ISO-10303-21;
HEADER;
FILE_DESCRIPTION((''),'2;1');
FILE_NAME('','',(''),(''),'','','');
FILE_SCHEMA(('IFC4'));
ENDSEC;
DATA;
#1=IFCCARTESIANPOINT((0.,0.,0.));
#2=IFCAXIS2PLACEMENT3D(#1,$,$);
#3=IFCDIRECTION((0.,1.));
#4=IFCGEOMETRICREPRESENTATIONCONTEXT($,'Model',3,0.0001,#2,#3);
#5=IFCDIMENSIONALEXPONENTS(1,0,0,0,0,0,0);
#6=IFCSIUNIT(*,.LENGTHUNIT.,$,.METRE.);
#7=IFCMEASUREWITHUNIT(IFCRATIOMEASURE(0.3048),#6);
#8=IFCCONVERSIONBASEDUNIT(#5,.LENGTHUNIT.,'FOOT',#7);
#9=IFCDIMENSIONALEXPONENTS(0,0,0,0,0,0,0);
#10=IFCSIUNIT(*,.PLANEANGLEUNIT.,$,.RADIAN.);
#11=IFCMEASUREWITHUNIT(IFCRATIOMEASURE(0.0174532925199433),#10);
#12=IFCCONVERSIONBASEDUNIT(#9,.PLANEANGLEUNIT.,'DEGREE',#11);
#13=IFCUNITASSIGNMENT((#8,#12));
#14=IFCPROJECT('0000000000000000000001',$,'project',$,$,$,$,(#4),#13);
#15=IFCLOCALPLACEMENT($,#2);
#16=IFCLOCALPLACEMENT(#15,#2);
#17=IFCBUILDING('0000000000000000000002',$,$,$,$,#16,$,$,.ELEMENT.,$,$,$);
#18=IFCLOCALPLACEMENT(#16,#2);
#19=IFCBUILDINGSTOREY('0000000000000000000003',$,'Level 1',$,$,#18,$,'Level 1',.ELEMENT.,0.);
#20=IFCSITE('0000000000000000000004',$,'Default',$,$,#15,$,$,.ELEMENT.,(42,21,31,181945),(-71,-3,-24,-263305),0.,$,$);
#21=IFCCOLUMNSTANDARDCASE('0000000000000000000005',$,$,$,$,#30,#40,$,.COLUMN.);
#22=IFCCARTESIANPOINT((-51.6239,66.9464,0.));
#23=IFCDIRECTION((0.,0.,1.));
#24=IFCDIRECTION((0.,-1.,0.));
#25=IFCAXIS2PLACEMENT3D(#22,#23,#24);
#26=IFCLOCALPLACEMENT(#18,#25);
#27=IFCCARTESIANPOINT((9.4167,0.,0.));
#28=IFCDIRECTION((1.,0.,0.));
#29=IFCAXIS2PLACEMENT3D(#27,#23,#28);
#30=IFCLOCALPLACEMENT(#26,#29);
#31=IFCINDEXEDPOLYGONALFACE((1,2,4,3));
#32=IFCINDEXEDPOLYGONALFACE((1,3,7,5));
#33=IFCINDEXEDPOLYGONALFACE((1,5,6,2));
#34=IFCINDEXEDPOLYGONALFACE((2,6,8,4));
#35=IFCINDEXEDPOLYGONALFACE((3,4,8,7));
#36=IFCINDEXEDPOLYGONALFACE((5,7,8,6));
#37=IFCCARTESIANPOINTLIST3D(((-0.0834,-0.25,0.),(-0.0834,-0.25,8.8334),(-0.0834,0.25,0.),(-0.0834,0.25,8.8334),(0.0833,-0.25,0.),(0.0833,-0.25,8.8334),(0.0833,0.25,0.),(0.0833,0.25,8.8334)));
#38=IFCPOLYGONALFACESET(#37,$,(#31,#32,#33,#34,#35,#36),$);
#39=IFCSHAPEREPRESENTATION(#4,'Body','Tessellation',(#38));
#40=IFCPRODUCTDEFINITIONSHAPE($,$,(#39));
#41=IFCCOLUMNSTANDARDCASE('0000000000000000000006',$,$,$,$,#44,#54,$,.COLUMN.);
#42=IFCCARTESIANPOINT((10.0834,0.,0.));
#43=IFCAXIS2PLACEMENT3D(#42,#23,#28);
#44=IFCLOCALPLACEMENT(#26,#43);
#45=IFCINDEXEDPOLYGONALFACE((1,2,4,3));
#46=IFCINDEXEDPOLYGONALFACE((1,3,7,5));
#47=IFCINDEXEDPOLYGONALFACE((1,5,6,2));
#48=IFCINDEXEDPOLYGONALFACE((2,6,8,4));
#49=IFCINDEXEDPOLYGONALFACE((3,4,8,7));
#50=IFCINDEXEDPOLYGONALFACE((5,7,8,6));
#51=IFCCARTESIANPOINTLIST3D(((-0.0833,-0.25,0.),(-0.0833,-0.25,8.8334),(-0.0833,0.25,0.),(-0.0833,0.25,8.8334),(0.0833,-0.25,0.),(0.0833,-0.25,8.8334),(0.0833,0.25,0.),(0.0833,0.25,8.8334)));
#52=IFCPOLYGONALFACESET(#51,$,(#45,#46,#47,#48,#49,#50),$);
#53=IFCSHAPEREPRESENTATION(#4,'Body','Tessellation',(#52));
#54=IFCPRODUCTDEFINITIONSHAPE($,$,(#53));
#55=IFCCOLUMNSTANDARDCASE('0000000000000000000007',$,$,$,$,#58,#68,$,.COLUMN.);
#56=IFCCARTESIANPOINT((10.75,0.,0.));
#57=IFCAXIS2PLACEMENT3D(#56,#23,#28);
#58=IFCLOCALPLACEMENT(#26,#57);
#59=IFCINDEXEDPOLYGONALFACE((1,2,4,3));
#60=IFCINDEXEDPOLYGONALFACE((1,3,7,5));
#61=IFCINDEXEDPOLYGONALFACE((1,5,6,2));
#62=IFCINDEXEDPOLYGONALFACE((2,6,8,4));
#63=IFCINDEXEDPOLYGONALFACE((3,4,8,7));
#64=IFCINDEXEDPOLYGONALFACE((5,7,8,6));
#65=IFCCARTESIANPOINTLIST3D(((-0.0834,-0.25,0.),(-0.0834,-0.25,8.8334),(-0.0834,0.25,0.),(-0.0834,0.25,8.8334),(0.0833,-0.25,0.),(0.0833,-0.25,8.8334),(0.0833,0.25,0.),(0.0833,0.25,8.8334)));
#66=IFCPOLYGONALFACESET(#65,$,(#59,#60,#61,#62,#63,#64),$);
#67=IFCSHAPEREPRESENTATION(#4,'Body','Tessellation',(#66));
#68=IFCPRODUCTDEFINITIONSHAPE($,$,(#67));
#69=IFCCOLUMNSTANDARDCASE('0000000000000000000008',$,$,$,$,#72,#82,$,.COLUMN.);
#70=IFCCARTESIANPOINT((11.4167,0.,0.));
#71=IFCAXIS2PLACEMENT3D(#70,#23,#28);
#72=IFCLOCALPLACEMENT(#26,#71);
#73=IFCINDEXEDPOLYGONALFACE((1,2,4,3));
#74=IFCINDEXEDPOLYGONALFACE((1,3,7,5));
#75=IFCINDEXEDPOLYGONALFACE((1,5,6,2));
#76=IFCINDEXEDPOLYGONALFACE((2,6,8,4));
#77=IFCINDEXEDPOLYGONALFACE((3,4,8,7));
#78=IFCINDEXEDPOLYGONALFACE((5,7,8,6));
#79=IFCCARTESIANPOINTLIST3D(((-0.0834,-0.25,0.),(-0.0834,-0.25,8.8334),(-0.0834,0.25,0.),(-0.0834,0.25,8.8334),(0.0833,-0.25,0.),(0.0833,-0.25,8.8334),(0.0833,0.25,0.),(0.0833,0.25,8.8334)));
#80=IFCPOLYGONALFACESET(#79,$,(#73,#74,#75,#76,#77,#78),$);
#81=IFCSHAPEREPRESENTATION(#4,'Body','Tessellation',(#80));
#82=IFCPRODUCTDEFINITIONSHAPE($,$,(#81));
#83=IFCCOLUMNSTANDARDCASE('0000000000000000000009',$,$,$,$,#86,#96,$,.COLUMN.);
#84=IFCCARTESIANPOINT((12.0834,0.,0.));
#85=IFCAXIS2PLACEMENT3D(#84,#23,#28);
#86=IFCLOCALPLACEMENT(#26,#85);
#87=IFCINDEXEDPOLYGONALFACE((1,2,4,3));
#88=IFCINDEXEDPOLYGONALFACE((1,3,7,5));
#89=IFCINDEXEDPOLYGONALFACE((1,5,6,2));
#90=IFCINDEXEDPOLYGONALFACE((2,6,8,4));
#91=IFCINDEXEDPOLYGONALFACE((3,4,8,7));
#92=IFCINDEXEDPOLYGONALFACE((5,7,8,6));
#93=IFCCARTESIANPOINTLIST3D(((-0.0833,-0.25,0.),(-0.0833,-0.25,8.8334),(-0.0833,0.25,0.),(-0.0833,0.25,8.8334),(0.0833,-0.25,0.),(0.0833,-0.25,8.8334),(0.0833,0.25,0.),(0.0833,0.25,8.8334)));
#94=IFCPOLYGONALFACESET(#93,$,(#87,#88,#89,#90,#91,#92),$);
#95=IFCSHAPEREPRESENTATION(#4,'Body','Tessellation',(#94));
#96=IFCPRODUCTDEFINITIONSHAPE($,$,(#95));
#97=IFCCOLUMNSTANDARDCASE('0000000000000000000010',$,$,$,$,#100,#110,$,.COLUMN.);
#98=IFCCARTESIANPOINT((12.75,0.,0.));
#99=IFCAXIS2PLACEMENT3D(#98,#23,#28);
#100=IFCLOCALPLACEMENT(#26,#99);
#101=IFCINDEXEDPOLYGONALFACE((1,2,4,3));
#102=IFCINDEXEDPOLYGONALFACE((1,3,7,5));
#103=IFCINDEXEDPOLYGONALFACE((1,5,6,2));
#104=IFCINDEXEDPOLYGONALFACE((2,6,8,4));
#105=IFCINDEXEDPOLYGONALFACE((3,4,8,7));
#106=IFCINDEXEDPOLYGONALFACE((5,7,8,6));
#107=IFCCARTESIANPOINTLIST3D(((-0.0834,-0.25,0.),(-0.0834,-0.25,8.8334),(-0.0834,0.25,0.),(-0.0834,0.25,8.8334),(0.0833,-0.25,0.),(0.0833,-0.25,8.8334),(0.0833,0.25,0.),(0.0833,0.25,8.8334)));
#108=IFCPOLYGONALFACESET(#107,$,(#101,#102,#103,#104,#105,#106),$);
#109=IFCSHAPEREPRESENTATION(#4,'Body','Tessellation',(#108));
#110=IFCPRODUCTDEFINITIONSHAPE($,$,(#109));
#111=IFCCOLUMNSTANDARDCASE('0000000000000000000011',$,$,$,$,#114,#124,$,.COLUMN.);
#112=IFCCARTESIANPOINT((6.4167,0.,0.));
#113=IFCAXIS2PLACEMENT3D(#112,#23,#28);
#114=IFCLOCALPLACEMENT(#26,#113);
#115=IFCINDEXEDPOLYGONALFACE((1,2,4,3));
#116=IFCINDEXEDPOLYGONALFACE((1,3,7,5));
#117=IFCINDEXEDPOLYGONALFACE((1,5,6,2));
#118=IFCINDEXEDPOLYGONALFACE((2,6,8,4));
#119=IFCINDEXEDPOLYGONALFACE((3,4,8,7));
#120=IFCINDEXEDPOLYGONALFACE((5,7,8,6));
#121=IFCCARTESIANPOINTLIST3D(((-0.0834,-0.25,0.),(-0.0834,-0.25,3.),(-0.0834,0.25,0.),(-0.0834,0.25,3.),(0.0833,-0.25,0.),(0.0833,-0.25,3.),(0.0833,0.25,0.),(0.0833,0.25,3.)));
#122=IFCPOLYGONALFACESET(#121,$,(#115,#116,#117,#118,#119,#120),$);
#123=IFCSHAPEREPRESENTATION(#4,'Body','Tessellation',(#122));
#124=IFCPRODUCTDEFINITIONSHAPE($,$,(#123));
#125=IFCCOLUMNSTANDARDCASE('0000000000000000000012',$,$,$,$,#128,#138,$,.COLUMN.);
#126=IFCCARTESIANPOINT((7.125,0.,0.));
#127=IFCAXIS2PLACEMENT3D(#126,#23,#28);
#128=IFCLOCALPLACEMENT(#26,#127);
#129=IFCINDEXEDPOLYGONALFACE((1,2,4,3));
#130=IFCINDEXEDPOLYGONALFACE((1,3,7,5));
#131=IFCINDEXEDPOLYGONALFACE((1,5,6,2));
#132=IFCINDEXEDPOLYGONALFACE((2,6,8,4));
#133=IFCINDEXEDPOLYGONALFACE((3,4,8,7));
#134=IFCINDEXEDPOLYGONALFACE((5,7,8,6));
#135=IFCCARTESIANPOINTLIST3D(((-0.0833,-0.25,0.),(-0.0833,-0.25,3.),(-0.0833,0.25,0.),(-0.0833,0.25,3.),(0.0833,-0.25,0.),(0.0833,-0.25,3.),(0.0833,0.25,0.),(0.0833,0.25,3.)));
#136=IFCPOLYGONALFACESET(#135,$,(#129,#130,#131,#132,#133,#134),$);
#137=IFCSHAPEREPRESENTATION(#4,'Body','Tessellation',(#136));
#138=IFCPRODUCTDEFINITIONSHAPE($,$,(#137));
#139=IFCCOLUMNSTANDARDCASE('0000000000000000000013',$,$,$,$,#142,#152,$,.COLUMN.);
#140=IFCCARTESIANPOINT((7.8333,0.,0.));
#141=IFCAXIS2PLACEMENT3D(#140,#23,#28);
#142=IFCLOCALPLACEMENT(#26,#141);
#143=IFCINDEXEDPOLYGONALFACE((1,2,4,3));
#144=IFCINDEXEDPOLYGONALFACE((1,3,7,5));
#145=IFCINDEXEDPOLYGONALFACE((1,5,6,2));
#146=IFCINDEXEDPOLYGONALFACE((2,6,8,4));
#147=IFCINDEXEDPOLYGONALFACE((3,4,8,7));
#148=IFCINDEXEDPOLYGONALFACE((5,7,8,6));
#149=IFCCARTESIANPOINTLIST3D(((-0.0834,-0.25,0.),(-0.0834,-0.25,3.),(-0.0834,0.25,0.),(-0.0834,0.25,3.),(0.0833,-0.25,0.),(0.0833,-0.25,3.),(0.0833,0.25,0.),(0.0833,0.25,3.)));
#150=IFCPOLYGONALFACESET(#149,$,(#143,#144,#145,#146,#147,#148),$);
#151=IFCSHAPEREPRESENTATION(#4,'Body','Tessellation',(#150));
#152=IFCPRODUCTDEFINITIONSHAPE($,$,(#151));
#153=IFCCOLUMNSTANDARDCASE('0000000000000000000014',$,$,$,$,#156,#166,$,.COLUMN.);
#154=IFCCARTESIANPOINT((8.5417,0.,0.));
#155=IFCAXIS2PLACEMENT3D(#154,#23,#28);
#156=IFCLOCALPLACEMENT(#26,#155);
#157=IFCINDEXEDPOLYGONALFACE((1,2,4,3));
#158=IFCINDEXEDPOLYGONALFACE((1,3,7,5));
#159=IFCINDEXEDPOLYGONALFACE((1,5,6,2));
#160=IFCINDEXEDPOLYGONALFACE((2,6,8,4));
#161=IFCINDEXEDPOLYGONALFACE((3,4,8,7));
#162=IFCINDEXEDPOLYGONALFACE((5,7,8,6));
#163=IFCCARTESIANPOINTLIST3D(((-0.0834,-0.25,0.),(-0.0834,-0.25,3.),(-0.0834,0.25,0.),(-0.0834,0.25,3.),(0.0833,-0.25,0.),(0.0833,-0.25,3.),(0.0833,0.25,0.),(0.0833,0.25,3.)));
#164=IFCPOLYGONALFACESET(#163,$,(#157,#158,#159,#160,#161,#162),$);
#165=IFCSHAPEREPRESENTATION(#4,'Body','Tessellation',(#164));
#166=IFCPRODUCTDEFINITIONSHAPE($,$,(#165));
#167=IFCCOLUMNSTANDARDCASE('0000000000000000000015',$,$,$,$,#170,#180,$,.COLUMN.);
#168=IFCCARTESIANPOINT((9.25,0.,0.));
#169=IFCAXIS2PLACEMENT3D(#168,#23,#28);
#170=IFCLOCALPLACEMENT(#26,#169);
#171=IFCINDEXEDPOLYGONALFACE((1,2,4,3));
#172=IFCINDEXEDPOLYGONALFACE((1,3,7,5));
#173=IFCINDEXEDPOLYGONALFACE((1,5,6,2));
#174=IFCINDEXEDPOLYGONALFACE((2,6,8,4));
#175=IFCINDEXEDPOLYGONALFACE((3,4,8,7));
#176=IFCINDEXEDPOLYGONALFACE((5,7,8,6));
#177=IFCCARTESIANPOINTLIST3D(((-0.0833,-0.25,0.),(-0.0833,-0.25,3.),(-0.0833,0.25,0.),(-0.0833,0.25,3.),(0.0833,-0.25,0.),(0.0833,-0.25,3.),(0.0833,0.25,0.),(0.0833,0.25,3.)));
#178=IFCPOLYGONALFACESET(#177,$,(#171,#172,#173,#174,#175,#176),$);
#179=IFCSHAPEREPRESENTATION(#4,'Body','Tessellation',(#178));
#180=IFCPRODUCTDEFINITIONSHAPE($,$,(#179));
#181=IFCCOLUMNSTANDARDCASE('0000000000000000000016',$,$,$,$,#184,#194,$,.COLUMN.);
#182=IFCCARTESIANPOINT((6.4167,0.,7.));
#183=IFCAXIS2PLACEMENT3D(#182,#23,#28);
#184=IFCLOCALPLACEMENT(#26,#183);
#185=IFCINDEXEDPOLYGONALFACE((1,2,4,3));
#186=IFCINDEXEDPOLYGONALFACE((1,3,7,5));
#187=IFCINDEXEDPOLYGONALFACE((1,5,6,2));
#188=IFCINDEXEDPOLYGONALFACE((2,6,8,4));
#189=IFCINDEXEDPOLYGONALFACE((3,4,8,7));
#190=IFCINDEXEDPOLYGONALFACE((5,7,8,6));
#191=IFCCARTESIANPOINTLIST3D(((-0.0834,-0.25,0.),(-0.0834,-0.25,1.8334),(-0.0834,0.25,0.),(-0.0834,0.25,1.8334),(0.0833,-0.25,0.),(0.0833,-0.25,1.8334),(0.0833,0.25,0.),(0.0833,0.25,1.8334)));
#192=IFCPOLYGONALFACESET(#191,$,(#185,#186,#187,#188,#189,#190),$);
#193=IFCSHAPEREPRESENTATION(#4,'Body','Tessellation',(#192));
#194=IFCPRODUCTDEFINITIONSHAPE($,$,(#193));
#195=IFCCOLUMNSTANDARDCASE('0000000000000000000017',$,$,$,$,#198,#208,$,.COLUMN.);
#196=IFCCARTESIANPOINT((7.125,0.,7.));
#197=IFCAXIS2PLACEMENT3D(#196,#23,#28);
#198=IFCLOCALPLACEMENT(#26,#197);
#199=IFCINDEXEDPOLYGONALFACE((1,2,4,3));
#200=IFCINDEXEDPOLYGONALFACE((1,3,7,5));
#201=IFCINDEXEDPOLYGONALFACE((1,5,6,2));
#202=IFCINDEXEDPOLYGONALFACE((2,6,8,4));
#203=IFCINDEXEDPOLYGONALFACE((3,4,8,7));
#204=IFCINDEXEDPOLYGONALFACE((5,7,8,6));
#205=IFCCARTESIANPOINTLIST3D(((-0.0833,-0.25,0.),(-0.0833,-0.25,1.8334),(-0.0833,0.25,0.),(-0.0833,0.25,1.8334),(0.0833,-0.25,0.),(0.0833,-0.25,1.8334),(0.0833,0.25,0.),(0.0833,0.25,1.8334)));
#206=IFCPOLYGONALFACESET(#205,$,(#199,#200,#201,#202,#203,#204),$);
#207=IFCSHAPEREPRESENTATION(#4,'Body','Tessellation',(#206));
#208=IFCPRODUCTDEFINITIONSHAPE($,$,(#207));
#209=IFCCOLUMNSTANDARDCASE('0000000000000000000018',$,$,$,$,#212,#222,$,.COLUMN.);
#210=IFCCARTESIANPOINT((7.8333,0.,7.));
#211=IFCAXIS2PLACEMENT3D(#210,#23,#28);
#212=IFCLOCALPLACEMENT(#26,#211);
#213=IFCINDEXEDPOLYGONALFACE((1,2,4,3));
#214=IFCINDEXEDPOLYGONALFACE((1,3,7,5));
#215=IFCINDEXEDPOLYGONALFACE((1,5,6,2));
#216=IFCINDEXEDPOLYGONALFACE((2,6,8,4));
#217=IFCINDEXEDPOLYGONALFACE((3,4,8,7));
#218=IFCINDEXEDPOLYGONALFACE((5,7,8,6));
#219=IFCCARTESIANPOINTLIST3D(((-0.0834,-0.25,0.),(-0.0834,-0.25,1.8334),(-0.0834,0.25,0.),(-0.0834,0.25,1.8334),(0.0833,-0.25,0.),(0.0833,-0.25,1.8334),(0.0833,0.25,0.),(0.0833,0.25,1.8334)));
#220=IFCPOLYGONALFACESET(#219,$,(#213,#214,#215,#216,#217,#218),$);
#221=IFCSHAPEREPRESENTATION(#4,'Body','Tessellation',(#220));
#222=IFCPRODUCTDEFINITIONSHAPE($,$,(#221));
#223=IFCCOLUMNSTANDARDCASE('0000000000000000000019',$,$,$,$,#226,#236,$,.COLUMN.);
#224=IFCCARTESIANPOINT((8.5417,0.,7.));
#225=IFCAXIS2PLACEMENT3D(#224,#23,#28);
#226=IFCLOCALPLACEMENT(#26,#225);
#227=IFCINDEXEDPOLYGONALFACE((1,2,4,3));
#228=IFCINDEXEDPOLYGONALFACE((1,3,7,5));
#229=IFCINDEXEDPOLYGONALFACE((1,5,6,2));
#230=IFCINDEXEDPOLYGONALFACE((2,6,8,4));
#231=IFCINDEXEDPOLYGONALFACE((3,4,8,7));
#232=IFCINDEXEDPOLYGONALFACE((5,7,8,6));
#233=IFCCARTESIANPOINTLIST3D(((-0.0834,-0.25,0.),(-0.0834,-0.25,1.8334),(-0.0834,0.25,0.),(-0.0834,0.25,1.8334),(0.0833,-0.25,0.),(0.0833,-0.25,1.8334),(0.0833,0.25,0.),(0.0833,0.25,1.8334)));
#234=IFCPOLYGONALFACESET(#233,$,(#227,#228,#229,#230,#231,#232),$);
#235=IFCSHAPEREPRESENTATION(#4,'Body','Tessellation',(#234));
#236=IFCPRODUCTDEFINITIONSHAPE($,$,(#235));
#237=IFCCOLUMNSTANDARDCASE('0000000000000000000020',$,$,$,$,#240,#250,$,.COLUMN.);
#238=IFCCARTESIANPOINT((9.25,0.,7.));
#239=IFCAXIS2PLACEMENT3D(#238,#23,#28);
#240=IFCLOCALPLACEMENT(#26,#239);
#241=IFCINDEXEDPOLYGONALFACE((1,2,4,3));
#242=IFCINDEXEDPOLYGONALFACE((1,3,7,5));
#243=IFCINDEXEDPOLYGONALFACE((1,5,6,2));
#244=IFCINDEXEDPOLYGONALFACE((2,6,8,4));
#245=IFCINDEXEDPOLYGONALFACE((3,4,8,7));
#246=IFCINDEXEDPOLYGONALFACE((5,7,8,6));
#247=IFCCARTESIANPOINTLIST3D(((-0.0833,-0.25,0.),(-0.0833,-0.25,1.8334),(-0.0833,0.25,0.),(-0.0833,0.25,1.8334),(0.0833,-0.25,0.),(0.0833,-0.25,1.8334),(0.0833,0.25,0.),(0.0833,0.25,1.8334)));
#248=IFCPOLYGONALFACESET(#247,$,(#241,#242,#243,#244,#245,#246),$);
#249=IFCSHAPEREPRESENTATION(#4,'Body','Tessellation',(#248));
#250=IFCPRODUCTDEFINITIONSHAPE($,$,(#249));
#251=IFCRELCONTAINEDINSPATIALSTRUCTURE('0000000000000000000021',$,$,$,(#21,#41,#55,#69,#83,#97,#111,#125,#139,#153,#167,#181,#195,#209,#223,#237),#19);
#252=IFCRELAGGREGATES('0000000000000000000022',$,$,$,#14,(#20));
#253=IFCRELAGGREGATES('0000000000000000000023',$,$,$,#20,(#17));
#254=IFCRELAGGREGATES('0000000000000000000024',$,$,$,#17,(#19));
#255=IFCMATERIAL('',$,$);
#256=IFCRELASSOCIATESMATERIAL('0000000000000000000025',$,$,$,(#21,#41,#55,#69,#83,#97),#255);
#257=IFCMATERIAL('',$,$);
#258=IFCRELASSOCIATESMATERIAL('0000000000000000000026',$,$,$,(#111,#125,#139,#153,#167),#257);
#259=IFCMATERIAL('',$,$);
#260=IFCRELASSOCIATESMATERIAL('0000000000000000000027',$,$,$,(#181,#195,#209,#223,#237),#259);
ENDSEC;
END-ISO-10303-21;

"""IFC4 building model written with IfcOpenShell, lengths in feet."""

from ifc_helpers import new_model, entity, si_unit, converted_unit, direction, frame, origin, place, context, project, spatial, rectangle, extrude, material, element, save


model = new_model("IFC4")

# Units and contexts
model_context = context("Model", 3, precision=0.0001, world=origin(), true_north=direction((0.0, 1.0)))
ifc_project = project(units=[converted_unit("LENGTHUNIT", "FOOT", entity("IfcRatioMeasure", 0.3048), si_unit("LENGTHUNIT", "METRE"), dimensions=[1, 0, 0, 0, 0, 0, 0]), converted_unit("PLANEANGLEUNIT", "DEGREE", entity("IfcRatioMeasure", 0.0174532925199433), si_unit("PLANEANGLEUNIT", "RADIAN"), dimensions=[0, 0, 0, 0, 0, 0, 0])], contexts=[model_context])

# Site, building, storey
site_placement = place(None, origin())
site = spatial("IfcSite", under=ifc_project, at=site_placement, Name="Default", CompositionType="ELEMENT", RefLatitude=(42, 21, 31, 181945), RefLongitude=(-71, -3, -24, -263305), RefElevation=0.0)
building_placement = place(site_placement, origin())
building = spatial("IfcBuilding", under=site, at=building_placement, CompositionType="ELEMENT")
storey_placement = place(building_placement, origin())
storey = spatial("IfcBuildingStorey", under=building, at=storey_placement, Name="Level 1", LongName="Level 1", CompositionType="ELEMENT", Elevation=0.0)

# Columns
ifc_material_1 = material(Name="")
placement_1 = place(storey_placement, frame((-51.6239, 66.9464, 0.0), z_axis=(0.0, 0.0, 1.0), x_axis=(0.0, -1.0, 0.0)))
for number, where, z_axis, x_axis in (
    (1, (9.4167, 0.0, 0.0), (0.0, 0.0, 1.0), (1.0, 0.0, 0.0)),
    (2, (10.0834, 0.0, 0.0), (0.0, 0.0, 1.0), (1.0, 0.0, 0.0)),
    (3, (10.75, 0.0, 0.0), (0.0, 0.0, 1.0), (1.0, 0.0, 0.0)),
    (4, (11.4167, 0.0, 0.0), (0.0, 0.0, 1.0), (1.0, 0.0, 0.0)),
    (5, (12.0834, 0.0, 0.0), (0.0, 0.0, 1.0), (1.0, 0.0, 0.0)),
    (6, (12.75, 0.0, 0.0), (0.0, 0.0, 1.0), (1.0, 0.0, 0.0)),
):
    element("IfcColumnStandardCase", number, at=place(placement_1, frame(where, z_axis=z_axis, x_axis=x_axis)), inside=storey, material=ifc_material_1, PredefinedType="COLUMN", context=model_context, shape_type="SweptSolid", body=[
        extrude(rectangle(XDim=0.1667, YDim=0.5), origin(), (0.0, 0.0, 1.0), 8.8334),
    ])
ifc_material_2 = material(Name="")
for number, where, z_axis, x_axis in (
    (7, (6.4167, 0.0, 0.0), (0.0, 0.0, 1.0), (1.0, 0.0, 0.0)),
    (8, (7.125, 0.0, 0.0), (0.0, 0.0, 1.0), (1.0, 0.0, 0.0)),
    (9, (7.8333, 0.0, 0.0), (0.0, 0.0, 1.0), (1.0, 0.0, 0.0)),
    (10, (8.5417, 0.0, 0.0), (0.0, 0.0, 1.0), (1.0, 0.0, 0.0)),
    (11, (9.25, 0.0, 0.0), (0.0, 0.0, 1.0), (1.0, 0.0, 0.0)),
):
    element("IfcColumnStandardCase", number, at=place(placement_1, frame(where, z_axis=z_axis, x_axis=x_axis)), inside=storey, material=ifc_material_2, PredefinedType="COLUMN", context=model_context, shape_type="SweptSolid", body=[
        extrude(rectangle(XDim=0.1667, YDim=0.5), origin(), (0.0, 0.0, 1.0), 3.0),
    ])
ifc_material_3 = material(Name="")
for number, where, z_axis, x_axis in (
    (12, (6.4167, 0.0, 7.0), (0.0, 0.0, 1.0), (1.0, 0.0, 0.0)),
    (13, (7.125, 0.0, 7.0), (0.0, 0.0, 1.0), (1.0, 0.0, 0.0)),
    (14, (7.8333, 0.0, 7.0), (0.0, 0.0, 1.0), (1.0, 0.0, 0.0)),
    (15, (8.5417, 0.0, 7.0), (0.0, 0.0, 1.0), (1.0, 0.0, 0.0)),
    (16, (9.25, 0.0, 7.0), (0.0, 0.0, 1.0), (1.0, 0.0, 0.0)),
):
    element("IfcColumnStandardCase", number, at=place(placement_1, frame(where, z_axis=z_axis, x_axis=x_axis)), inside=storey, material=ifc_material_3, PredefinedType="COLUMN", context=model_context, shape_type="SweptSolid", body=[
        extrude(rectangle(XDim=0.1667, YDim=0.5), origin(), (0.0, 0.0, 1.0), 1.8334),
    ])

save(model, "model.ifc")
